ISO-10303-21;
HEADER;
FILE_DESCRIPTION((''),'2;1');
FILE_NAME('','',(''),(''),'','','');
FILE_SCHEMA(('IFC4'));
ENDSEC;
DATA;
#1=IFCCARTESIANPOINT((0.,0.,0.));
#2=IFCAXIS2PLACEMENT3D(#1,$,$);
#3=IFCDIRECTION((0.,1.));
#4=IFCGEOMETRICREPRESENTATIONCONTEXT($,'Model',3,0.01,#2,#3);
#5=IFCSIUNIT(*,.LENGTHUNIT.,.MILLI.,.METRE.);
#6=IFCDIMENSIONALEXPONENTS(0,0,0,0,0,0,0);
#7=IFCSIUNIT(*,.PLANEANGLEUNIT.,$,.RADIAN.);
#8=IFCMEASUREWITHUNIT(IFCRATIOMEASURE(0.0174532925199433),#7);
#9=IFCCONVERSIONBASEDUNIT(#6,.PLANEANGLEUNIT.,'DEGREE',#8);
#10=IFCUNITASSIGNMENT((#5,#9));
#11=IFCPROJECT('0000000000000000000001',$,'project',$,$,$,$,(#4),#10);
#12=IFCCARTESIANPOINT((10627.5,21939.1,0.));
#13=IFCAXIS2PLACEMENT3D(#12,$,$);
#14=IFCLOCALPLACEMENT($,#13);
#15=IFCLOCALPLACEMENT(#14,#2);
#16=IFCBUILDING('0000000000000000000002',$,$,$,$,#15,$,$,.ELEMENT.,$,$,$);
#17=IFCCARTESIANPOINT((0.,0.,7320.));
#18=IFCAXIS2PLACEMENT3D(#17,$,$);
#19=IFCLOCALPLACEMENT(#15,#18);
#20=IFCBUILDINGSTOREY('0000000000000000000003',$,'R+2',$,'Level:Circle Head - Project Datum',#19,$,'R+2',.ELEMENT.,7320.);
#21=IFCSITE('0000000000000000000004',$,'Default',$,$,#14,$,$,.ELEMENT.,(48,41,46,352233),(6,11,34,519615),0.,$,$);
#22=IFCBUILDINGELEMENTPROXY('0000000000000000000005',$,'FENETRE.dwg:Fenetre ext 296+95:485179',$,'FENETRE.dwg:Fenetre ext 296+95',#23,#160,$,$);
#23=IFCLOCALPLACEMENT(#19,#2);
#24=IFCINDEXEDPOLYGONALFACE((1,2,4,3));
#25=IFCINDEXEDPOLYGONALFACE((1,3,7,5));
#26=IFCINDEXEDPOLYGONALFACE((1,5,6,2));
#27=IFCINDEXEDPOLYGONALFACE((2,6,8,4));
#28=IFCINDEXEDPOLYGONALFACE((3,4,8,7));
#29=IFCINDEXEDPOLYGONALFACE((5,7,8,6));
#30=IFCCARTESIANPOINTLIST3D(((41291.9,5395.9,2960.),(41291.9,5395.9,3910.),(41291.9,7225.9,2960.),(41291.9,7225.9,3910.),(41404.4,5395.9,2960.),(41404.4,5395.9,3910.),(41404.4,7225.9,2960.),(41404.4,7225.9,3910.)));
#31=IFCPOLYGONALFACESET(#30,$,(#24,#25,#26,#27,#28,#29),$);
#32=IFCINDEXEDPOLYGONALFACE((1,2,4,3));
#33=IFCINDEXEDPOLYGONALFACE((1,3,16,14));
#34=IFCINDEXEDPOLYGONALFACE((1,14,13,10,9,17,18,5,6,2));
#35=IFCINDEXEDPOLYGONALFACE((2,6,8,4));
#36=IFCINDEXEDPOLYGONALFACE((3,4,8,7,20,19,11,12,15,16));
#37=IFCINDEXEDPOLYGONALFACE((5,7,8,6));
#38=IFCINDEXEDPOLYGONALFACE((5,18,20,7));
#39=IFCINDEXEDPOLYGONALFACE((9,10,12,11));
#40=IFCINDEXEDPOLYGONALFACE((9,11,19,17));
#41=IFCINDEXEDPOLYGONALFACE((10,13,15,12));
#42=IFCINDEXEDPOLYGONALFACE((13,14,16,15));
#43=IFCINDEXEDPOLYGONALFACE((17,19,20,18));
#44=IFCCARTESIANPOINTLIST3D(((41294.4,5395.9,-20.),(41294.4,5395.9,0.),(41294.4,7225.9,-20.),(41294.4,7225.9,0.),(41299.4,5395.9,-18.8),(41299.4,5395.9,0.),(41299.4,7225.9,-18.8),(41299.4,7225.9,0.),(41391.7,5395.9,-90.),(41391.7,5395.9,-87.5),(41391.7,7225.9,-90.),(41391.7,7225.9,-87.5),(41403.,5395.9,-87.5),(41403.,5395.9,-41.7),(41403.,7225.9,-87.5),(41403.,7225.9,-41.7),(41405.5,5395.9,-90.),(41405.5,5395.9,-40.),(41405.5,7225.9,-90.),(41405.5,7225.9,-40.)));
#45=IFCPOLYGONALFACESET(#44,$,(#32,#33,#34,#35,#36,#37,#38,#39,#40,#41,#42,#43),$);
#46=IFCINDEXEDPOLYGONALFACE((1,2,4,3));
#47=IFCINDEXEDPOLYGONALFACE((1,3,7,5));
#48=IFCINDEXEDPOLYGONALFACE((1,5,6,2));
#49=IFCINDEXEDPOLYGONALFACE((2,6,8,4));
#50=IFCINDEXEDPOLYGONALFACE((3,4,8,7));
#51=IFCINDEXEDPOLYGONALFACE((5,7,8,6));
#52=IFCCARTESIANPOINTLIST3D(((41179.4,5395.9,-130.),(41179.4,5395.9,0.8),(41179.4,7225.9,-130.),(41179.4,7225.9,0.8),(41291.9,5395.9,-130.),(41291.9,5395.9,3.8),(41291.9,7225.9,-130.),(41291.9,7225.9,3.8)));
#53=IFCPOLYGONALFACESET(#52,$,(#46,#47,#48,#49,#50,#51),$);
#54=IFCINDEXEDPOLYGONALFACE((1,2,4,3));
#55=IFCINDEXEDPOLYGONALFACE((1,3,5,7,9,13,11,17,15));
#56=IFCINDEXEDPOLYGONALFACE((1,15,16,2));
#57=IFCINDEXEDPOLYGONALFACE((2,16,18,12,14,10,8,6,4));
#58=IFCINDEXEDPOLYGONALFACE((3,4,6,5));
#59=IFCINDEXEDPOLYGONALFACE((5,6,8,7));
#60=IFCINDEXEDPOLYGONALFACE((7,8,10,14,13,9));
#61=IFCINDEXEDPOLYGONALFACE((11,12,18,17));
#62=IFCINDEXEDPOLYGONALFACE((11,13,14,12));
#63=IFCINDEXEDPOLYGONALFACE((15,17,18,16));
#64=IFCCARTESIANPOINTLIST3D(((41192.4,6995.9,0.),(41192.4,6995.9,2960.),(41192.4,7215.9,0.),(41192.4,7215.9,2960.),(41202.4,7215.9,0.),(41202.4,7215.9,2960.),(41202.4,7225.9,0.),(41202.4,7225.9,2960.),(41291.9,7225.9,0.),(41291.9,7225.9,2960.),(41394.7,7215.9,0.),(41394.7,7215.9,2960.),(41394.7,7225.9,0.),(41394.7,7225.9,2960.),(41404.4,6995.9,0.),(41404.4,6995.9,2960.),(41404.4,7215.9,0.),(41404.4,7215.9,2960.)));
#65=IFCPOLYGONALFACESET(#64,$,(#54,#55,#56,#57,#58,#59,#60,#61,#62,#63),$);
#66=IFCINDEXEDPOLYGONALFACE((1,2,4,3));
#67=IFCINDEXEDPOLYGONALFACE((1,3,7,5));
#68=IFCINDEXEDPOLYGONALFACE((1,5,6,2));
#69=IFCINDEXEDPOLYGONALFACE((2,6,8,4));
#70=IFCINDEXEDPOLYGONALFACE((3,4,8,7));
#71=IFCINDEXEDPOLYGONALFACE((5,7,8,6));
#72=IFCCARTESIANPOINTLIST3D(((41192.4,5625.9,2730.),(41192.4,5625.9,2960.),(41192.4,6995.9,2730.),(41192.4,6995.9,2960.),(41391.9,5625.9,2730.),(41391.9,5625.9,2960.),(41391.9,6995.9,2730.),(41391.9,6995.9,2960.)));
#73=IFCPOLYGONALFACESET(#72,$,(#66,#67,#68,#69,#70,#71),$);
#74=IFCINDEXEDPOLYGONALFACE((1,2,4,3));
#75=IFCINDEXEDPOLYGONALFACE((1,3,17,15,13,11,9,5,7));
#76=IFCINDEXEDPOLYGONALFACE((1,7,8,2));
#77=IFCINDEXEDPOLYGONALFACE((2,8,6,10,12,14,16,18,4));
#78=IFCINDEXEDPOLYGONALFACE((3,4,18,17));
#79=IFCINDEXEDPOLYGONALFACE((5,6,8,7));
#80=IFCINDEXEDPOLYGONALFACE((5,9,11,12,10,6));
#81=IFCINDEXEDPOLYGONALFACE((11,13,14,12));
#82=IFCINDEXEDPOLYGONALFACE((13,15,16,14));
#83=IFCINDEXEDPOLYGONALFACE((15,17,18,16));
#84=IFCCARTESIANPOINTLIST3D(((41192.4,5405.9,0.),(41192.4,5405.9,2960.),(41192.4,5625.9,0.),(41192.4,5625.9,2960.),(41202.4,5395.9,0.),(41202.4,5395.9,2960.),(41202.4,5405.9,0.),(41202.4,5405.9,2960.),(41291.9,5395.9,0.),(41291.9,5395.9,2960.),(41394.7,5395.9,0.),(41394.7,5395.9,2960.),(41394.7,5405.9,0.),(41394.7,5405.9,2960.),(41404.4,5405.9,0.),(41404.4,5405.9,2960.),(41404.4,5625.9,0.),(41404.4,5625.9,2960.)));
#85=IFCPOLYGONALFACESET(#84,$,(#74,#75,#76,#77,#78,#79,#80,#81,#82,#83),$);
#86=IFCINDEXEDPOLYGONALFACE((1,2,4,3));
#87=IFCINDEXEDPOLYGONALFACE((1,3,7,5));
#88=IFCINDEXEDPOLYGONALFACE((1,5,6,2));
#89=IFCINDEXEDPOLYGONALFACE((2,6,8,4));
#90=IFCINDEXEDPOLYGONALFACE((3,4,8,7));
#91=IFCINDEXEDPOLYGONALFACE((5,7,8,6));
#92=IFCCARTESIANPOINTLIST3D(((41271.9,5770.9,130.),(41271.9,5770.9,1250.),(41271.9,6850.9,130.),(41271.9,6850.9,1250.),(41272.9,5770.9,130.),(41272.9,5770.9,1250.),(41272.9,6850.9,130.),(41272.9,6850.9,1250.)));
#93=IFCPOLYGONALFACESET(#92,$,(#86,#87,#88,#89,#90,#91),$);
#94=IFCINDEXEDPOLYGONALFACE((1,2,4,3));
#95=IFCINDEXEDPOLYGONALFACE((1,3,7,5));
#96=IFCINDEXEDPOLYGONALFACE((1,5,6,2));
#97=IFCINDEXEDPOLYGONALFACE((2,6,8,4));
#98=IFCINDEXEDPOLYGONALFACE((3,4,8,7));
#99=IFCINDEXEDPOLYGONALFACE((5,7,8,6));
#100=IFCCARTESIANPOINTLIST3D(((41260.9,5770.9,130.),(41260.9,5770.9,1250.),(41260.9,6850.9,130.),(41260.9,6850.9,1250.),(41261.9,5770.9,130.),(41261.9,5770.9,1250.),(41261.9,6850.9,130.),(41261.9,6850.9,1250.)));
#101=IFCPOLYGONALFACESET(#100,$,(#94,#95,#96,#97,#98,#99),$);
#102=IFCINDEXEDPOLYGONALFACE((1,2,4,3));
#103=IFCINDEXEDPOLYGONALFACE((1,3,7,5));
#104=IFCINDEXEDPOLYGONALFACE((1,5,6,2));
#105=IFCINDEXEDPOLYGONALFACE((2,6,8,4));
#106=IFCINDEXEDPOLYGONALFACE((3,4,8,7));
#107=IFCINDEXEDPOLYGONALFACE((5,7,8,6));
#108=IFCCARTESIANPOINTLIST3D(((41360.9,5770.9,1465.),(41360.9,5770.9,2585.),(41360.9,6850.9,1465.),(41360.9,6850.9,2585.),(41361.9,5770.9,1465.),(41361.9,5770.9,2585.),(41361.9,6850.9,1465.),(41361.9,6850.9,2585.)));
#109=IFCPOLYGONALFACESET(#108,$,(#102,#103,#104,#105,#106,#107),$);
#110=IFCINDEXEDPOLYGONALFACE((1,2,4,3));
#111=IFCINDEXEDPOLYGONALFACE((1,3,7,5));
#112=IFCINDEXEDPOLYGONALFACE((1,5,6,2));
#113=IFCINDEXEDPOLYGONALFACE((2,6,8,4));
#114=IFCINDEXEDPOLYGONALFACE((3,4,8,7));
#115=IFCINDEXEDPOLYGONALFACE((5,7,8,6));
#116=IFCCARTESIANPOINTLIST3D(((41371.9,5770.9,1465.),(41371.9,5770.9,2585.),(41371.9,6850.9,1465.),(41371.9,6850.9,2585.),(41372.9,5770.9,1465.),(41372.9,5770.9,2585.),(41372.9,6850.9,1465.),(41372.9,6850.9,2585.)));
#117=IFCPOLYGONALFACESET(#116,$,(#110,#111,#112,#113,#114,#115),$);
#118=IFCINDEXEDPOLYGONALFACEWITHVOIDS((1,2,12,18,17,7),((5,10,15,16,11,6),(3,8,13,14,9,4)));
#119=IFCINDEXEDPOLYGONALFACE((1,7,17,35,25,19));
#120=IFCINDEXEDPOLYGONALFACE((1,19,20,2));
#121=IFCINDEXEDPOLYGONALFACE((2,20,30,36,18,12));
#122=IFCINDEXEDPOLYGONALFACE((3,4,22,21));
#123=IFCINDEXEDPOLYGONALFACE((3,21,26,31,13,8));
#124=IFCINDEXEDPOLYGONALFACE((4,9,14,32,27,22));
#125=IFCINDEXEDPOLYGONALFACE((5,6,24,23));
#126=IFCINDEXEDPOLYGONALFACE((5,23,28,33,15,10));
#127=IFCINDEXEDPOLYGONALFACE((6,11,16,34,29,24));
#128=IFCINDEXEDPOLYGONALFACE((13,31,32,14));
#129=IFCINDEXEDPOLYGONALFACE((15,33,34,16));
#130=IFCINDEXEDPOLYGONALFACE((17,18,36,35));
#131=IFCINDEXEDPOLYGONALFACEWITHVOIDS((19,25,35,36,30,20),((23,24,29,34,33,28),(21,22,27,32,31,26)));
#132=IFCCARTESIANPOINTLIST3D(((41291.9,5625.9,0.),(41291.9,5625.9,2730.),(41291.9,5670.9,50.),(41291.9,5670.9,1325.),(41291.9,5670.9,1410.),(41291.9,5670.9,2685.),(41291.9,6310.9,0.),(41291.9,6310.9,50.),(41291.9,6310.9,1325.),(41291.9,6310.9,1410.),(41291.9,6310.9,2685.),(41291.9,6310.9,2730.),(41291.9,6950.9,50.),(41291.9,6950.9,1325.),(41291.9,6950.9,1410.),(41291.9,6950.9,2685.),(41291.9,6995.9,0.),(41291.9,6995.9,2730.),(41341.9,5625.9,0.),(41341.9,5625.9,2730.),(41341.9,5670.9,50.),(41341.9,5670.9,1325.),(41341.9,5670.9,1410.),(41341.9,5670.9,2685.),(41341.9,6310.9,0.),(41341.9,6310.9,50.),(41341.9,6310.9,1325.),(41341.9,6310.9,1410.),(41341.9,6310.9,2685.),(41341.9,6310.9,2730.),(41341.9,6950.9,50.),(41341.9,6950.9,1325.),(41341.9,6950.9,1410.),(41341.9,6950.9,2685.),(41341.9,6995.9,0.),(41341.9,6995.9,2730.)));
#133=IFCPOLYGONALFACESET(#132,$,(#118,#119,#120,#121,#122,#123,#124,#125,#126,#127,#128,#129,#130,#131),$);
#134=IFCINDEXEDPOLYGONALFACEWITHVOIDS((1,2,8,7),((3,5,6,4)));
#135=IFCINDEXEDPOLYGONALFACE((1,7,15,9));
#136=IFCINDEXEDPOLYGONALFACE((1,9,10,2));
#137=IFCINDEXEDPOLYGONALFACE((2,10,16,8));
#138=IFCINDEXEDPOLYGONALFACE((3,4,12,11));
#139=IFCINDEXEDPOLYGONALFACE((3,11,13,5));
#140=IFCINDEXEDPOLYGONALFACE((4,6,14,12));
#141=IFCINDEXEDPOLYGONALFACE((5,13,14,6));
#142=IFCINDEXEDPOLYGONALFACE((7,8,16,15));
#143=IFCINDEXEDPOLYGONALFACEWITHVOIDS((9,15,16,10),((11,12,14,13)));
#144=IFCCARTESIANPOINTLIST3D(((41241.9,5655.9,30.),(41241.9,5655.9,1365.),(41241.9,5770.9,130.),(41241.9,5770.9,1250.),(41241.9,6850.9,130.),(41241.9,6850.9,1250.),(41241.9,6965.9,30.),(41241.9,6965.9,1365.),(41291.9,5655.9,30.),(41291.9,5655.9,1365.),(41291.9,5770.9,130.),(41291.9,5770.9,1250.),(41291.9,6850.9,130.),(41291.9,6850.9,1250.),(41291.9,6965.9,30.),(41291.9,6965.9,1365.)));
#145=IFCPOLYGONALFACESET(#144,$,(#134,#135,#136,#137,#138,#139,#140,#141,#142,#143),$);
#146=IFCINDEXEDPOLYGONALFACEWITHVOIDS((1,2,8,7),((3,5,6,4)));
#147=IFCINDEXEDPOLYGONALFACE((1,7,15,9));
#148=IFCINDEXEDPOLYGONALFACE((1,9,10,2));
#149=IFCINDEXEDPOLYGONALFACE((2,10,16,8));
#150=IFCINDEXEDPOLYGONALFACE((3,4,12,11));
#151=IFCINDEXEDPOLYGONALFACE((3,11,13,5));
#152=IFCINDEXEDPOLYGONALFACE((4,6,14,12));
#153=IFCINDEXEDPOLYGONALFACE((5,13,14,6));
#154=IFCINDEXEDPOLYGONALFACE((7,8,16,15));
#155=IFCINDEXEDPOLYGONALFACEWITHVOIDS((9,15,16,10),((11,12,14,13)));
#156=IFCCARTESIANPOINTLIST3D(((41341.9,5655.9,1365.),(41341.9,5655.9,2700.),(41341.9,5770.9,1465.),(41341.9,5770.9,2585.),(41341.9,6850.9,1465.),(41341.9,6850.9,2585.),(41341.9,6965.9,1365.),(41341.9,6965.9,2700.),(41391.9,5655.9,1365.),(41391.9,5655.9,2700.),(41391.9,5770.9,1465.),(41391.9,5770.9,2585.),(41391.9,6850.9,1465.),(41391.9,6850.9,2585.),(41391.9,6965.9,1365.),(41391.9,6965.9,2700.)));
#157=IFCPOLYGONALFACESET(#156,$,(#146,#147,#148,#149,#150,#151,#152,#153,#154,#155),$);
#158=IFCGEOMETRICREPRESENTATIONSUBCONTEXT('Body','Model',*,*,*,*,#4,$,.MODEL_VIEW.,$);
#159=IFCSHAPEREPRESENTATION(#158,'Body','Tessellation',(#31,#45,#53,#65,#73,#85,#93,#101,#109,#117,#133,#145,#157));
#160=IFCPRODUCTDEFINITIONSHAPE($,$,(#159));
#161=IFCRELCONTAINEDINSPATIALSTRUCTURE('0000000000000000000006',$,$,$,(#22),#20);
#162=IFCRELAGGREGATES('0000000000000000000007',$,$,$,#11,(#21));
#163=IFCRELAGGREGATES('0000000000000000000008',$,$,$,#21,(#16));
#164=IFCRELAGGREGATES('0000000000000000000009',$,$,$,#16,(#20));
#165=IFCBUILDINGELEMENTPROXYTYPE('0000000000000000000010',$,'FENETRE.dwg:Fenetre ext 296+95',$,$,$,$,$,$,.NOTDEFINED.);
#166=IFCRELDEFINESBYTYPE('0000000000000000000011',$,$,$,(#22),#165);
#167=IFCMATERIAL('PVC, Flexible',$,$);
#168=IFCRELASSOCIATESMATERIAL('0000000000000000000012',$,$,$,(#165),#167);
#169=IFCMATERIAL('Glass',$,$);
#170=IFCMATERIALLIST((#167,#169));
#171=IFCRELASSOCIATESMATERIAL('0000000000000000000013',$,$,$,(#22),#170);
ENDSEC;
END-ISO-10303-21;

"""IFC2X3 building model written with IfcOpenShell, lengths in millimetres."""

from ifc_helpers import new_model, entity, si_unit, converted_unit, direction, frame, frame_2d, origin, origin_2d_with_axis, place, context, subcontext, project, spatial, polyline, rectangle, outline, extrude, source, transform, mapped, material, material_list, type_object, type_shapes, element, save


model = new_model("IFC2X3")

# Units and contexts
model_context = context("Model", 3, precision=0.01, world=origin(), true_north=direction((0.0, 1.0)))
body_context = subcontext(model_context, "Body", "Model", "MODEL_VIEW")
ifc_project = project(units=[si_unit("LENGTHUNIT", "METRE", prefix="MILLI"), converted_unit("PLANEANGLEUNIT", "DEGREE", entity("IfcRatioMeasure", 0.0174532925199433), si_unit("PLANEANGLEUNIT", "RADIAN"), dimensions=[0, 0, 0, 0, 0, 0, 0])], contexts=[model_context])

# Site, building, storey
site_placement = place(None, frame((10627.5, 21939.1, 0.0)))
site = spatial("IfcSite", under=ifc_project, at=site_placement, Name="Default", CompositionType="ELEMENT", RefLatitude=(48, 41, 46, 352233), RefLongitude=(6, 11, 34, 519615), RefElevation=0.0)
building_placement = place(site_placement, origin())
building = spatial("IfcBuilding", under=site, at=building_placement, CompositionType="ELEMENT")
storey_placement = place(building_placement, frame((0.0, 0.0, 7320.0)))
storey = spatial("IfcBuildingStorey", under=building, at=storey_placement, Name="R+2", ObjectType="Level:Circle Head - Project Datum", LongName="R+2", CompositionType="ELEMENT", Elevation=7320.0)

# Building element proxy
ifc_material_1 = material(Name="PVC, Flexible")
ifc_material_2 = material(Name="Glass")
building_element_proxy_type_1 = type_object("IfcBuildingElementProxyType", Name="FENETRE.dwg:Fenetre ext 296+95", PredefinedType="NOTDEFINED", material=ifc_material_1)
shared_shape_1 = source(origin(), body_context, "Body", "SweptSolid", [
    extrude(rectangle(XDim=112.5, YDim=1830.0, at=origin_2d_with_axis()), frame((-10.4, -56.3, 2960.0), z_axis=(0.0, 0.0, 1.0), x_axis=(0.0, 1.0, 0.0)), (0.0, 0.0, 1.0), 950.0),
    extrude(outline(polyline([(27.5, -64.4), (47.5, -64.4), (47.5, -59.4), (28.8, -59.4), (7.5, 46.7), (-42.5, 46.7), (-42.5, 32.9), (-40.0, 32.9), (-40.0, 44.2), (5.8, 44.2), (27.5, -64.4)])), frame((-925.4, -66.9, -47.5), z_axis=(1.0, 0.0, 0.0), x_axis=(0.0, 0.0, 1.0)), (0.0, 0.0, 1.0), 1830.0),
    extrude(outline(polyline([(-54.5, -66.1), (58.0, -66.1), (54.5, 67.6), (-58.0, 64.6), (-54.5, -66.1)])), frame((-925.4, 56.3, -63.8), z_axis=(1.0, 0.0, 0.0), x_axis=(0.0, -0.999645, 0.02665)), (0.0, 0.0, 1.0), 1830.0),
    extrude(outline(polyline([(-97.0, -55.6), (5.9, -55.6), (95.4, -55.6), (95.4, -45.6), (105.4, -45.6), (105.4, 174.4), (-106.6, 174.4), (-106.6, -45.6), (-97.0, -45.6), (-97.0, -55.6)])), frame((849.0, -5.9, 0.0), z_axis=(0.0, 0.0, 1.0), x_axis=(0.0, 1.0, 0.0)), (0.0, 0.0, 1.0), 2960.0),
    extrude(rectangle(XDim=1370.0, YDim=199.5, at=origin_2d_with_axis()), frame((-10.4, -0.3, 2730.0), z_axis=(0.0, 0.0, 1.0), x_axis=(-1.0, 0.0, 0.0)), (0.0, 0.0, 1.0), 230.0),
    extrude(outline(polyline([(-55.6, 97.0), (-55.6, -5.9), (-55.6, -95.4), (-45.6, -95.4), (-45.6, -105.4), (174.4, -105.4), (174.4, 106.6), (-45.6, 106.6), (-45.6, 97.0), (-55.6, 97.0)])), frame((-869.9, -5.9, 0.0), z_axis=(0.0, 0.0, -1.0), x_axis=(1.0, 0.0, 0.0)), (0.0, 0.0, -1.0), 2960.0),
    extrude(rectangle(XDim=1080.0, YDim=1.0, at=origin_2d_with_axis()), frame((-10.4, 19.5, 130.0), z_axis=(0.0, 0.0, 1.0), x_axis=(-1.0, 0.0, 0.0)), (0.0, 0.0, 1.0), 1120.0),
    extrude(rectangle(XDim=1080.0, YDim=1.0, at=origin_2d_with_axis()), frame((-10.4, 30.5, 130.0), z_axis=(0.0, 0.0, 1.0), x_axis=(-1.0, 0.0, 0.0)), (0.0, 0.0, 1.0), 1120.0),
    extrude(rectangle(XDim=1080.0, YDim=1.0, at=frame_2d((0.0, 0.0), x_axis=(1.0, 0.0))), frame((-10.4, -69.5, 1465.0), z_axis=(0.0, 0.0, 1.0), x_axis=(-1.0, 0.0, 0.0)), (0.0, 0.0, 1.0), 1120.0),
    extrude(rectangle(XDim=1080.0, YDim=1.0, at=frame_2d((0.0, 0.0), x_axis=(1.0, 0.0))), frame((-10.4, -80.5, 1465.0), z_axis=(0.0, 0.0, 1.0), x_axis=(-1.0, 0.0, 0.0)), (0.0, 0.0, 1.0), 1120.0),
    extrude(outline(polyline([(-685.0, -1365.0), (0.0, -1365.0), (685.0, -1365.0), (685.0, 1365.0), (0.0, 1365.0), (-685.0, 1365.0), (-685.0, -1365.0)]), holes=[polyline([(-640.0, -1320.0), (-640.0, -45.0), (0.0, -45.0), (640.0, -45.0), (640.0, -1320.0), (0.0, -1320.0), (-640.0, -1320.0)]), polyline([(-640.0, 40.0), (-640.0, 1315.0), (0.0, 1315.0), (640.0, 1315.0), (640.0, 40.0), (0.0, 40.0), (-640.0, 40.0)])]), frame((-10.4, -50.0, 1365.0), z_axis=(0.0, 1.0, 0.0), x_axis=(1.0, 0.0, 0.0)), (0.0, 0.0, 1.0), 50.0),
    extrude(outline(polyline([(-655.0, -667.5), (655.0, -667.5), (655.0, 667.5), (-655.0, 667.5), (-655.0, -667.5)]), holes=[polyline([(-540.0, 552.5), (540.0, 552.5), (540.0, -567.5), (-540.0, -567.5), (-540.0, 552.5)])]), frame((-10.4, 0.0, 697.5), z_axis=(0.0, 1.0, 0.0), x_axis=(-1.0, 0.0, 0.0)), (0.0, 0.0, 1.0), 50.0),
    extrude(outline(polyline([(-655.0, -667.5), (655.0, -667.5), (655.0, 667.5), (-655.0, 667.5), (-655.0, -667.5)]), holes=[polyline([(-540.0, 552.5), (540.0, 552.5), (540.0, -567.5), (-540.0, -567.5), (-540.0, 552.5)])]), frame((-10.4, -100.0, 2032.5), z_axis=(0.0, 1.0, 0.0), x_axis=(-1.0, 0.0, 0.0)), (0.0, 0.0, 1.0), 50.0),
])
type_shapes(building_element_proxy_type_1, [shared_shape_1])
ifc_material_list_1 = material_list([ifc_material_1, ifc_material_2])
proxy_1_placement = place(storey_placement, frame((41291.9, 6321.3, 0.0), z_axis=(0.0, 0.0, 1.0), x_axis=(0.0, 1.0, 0.0)))
element("IfcBuildingElementProxy", 1, at=proxy_1_placement, inside=storey, type_object=building_element_proxy_type_1, material=ifc_material_list_1, Name="FENETRE.dwg:Fenetre ext 296+95:485179", ObjectType="FENETRE.dwg:Fenetre ext 296+95", context=body_context, shape_type="MappedRepresentation", body=[
    mapped(shared_shape_1, transform((0.0, 0.0, 0.0), scale=1.0)),
])

save(model, "model.ifc")
